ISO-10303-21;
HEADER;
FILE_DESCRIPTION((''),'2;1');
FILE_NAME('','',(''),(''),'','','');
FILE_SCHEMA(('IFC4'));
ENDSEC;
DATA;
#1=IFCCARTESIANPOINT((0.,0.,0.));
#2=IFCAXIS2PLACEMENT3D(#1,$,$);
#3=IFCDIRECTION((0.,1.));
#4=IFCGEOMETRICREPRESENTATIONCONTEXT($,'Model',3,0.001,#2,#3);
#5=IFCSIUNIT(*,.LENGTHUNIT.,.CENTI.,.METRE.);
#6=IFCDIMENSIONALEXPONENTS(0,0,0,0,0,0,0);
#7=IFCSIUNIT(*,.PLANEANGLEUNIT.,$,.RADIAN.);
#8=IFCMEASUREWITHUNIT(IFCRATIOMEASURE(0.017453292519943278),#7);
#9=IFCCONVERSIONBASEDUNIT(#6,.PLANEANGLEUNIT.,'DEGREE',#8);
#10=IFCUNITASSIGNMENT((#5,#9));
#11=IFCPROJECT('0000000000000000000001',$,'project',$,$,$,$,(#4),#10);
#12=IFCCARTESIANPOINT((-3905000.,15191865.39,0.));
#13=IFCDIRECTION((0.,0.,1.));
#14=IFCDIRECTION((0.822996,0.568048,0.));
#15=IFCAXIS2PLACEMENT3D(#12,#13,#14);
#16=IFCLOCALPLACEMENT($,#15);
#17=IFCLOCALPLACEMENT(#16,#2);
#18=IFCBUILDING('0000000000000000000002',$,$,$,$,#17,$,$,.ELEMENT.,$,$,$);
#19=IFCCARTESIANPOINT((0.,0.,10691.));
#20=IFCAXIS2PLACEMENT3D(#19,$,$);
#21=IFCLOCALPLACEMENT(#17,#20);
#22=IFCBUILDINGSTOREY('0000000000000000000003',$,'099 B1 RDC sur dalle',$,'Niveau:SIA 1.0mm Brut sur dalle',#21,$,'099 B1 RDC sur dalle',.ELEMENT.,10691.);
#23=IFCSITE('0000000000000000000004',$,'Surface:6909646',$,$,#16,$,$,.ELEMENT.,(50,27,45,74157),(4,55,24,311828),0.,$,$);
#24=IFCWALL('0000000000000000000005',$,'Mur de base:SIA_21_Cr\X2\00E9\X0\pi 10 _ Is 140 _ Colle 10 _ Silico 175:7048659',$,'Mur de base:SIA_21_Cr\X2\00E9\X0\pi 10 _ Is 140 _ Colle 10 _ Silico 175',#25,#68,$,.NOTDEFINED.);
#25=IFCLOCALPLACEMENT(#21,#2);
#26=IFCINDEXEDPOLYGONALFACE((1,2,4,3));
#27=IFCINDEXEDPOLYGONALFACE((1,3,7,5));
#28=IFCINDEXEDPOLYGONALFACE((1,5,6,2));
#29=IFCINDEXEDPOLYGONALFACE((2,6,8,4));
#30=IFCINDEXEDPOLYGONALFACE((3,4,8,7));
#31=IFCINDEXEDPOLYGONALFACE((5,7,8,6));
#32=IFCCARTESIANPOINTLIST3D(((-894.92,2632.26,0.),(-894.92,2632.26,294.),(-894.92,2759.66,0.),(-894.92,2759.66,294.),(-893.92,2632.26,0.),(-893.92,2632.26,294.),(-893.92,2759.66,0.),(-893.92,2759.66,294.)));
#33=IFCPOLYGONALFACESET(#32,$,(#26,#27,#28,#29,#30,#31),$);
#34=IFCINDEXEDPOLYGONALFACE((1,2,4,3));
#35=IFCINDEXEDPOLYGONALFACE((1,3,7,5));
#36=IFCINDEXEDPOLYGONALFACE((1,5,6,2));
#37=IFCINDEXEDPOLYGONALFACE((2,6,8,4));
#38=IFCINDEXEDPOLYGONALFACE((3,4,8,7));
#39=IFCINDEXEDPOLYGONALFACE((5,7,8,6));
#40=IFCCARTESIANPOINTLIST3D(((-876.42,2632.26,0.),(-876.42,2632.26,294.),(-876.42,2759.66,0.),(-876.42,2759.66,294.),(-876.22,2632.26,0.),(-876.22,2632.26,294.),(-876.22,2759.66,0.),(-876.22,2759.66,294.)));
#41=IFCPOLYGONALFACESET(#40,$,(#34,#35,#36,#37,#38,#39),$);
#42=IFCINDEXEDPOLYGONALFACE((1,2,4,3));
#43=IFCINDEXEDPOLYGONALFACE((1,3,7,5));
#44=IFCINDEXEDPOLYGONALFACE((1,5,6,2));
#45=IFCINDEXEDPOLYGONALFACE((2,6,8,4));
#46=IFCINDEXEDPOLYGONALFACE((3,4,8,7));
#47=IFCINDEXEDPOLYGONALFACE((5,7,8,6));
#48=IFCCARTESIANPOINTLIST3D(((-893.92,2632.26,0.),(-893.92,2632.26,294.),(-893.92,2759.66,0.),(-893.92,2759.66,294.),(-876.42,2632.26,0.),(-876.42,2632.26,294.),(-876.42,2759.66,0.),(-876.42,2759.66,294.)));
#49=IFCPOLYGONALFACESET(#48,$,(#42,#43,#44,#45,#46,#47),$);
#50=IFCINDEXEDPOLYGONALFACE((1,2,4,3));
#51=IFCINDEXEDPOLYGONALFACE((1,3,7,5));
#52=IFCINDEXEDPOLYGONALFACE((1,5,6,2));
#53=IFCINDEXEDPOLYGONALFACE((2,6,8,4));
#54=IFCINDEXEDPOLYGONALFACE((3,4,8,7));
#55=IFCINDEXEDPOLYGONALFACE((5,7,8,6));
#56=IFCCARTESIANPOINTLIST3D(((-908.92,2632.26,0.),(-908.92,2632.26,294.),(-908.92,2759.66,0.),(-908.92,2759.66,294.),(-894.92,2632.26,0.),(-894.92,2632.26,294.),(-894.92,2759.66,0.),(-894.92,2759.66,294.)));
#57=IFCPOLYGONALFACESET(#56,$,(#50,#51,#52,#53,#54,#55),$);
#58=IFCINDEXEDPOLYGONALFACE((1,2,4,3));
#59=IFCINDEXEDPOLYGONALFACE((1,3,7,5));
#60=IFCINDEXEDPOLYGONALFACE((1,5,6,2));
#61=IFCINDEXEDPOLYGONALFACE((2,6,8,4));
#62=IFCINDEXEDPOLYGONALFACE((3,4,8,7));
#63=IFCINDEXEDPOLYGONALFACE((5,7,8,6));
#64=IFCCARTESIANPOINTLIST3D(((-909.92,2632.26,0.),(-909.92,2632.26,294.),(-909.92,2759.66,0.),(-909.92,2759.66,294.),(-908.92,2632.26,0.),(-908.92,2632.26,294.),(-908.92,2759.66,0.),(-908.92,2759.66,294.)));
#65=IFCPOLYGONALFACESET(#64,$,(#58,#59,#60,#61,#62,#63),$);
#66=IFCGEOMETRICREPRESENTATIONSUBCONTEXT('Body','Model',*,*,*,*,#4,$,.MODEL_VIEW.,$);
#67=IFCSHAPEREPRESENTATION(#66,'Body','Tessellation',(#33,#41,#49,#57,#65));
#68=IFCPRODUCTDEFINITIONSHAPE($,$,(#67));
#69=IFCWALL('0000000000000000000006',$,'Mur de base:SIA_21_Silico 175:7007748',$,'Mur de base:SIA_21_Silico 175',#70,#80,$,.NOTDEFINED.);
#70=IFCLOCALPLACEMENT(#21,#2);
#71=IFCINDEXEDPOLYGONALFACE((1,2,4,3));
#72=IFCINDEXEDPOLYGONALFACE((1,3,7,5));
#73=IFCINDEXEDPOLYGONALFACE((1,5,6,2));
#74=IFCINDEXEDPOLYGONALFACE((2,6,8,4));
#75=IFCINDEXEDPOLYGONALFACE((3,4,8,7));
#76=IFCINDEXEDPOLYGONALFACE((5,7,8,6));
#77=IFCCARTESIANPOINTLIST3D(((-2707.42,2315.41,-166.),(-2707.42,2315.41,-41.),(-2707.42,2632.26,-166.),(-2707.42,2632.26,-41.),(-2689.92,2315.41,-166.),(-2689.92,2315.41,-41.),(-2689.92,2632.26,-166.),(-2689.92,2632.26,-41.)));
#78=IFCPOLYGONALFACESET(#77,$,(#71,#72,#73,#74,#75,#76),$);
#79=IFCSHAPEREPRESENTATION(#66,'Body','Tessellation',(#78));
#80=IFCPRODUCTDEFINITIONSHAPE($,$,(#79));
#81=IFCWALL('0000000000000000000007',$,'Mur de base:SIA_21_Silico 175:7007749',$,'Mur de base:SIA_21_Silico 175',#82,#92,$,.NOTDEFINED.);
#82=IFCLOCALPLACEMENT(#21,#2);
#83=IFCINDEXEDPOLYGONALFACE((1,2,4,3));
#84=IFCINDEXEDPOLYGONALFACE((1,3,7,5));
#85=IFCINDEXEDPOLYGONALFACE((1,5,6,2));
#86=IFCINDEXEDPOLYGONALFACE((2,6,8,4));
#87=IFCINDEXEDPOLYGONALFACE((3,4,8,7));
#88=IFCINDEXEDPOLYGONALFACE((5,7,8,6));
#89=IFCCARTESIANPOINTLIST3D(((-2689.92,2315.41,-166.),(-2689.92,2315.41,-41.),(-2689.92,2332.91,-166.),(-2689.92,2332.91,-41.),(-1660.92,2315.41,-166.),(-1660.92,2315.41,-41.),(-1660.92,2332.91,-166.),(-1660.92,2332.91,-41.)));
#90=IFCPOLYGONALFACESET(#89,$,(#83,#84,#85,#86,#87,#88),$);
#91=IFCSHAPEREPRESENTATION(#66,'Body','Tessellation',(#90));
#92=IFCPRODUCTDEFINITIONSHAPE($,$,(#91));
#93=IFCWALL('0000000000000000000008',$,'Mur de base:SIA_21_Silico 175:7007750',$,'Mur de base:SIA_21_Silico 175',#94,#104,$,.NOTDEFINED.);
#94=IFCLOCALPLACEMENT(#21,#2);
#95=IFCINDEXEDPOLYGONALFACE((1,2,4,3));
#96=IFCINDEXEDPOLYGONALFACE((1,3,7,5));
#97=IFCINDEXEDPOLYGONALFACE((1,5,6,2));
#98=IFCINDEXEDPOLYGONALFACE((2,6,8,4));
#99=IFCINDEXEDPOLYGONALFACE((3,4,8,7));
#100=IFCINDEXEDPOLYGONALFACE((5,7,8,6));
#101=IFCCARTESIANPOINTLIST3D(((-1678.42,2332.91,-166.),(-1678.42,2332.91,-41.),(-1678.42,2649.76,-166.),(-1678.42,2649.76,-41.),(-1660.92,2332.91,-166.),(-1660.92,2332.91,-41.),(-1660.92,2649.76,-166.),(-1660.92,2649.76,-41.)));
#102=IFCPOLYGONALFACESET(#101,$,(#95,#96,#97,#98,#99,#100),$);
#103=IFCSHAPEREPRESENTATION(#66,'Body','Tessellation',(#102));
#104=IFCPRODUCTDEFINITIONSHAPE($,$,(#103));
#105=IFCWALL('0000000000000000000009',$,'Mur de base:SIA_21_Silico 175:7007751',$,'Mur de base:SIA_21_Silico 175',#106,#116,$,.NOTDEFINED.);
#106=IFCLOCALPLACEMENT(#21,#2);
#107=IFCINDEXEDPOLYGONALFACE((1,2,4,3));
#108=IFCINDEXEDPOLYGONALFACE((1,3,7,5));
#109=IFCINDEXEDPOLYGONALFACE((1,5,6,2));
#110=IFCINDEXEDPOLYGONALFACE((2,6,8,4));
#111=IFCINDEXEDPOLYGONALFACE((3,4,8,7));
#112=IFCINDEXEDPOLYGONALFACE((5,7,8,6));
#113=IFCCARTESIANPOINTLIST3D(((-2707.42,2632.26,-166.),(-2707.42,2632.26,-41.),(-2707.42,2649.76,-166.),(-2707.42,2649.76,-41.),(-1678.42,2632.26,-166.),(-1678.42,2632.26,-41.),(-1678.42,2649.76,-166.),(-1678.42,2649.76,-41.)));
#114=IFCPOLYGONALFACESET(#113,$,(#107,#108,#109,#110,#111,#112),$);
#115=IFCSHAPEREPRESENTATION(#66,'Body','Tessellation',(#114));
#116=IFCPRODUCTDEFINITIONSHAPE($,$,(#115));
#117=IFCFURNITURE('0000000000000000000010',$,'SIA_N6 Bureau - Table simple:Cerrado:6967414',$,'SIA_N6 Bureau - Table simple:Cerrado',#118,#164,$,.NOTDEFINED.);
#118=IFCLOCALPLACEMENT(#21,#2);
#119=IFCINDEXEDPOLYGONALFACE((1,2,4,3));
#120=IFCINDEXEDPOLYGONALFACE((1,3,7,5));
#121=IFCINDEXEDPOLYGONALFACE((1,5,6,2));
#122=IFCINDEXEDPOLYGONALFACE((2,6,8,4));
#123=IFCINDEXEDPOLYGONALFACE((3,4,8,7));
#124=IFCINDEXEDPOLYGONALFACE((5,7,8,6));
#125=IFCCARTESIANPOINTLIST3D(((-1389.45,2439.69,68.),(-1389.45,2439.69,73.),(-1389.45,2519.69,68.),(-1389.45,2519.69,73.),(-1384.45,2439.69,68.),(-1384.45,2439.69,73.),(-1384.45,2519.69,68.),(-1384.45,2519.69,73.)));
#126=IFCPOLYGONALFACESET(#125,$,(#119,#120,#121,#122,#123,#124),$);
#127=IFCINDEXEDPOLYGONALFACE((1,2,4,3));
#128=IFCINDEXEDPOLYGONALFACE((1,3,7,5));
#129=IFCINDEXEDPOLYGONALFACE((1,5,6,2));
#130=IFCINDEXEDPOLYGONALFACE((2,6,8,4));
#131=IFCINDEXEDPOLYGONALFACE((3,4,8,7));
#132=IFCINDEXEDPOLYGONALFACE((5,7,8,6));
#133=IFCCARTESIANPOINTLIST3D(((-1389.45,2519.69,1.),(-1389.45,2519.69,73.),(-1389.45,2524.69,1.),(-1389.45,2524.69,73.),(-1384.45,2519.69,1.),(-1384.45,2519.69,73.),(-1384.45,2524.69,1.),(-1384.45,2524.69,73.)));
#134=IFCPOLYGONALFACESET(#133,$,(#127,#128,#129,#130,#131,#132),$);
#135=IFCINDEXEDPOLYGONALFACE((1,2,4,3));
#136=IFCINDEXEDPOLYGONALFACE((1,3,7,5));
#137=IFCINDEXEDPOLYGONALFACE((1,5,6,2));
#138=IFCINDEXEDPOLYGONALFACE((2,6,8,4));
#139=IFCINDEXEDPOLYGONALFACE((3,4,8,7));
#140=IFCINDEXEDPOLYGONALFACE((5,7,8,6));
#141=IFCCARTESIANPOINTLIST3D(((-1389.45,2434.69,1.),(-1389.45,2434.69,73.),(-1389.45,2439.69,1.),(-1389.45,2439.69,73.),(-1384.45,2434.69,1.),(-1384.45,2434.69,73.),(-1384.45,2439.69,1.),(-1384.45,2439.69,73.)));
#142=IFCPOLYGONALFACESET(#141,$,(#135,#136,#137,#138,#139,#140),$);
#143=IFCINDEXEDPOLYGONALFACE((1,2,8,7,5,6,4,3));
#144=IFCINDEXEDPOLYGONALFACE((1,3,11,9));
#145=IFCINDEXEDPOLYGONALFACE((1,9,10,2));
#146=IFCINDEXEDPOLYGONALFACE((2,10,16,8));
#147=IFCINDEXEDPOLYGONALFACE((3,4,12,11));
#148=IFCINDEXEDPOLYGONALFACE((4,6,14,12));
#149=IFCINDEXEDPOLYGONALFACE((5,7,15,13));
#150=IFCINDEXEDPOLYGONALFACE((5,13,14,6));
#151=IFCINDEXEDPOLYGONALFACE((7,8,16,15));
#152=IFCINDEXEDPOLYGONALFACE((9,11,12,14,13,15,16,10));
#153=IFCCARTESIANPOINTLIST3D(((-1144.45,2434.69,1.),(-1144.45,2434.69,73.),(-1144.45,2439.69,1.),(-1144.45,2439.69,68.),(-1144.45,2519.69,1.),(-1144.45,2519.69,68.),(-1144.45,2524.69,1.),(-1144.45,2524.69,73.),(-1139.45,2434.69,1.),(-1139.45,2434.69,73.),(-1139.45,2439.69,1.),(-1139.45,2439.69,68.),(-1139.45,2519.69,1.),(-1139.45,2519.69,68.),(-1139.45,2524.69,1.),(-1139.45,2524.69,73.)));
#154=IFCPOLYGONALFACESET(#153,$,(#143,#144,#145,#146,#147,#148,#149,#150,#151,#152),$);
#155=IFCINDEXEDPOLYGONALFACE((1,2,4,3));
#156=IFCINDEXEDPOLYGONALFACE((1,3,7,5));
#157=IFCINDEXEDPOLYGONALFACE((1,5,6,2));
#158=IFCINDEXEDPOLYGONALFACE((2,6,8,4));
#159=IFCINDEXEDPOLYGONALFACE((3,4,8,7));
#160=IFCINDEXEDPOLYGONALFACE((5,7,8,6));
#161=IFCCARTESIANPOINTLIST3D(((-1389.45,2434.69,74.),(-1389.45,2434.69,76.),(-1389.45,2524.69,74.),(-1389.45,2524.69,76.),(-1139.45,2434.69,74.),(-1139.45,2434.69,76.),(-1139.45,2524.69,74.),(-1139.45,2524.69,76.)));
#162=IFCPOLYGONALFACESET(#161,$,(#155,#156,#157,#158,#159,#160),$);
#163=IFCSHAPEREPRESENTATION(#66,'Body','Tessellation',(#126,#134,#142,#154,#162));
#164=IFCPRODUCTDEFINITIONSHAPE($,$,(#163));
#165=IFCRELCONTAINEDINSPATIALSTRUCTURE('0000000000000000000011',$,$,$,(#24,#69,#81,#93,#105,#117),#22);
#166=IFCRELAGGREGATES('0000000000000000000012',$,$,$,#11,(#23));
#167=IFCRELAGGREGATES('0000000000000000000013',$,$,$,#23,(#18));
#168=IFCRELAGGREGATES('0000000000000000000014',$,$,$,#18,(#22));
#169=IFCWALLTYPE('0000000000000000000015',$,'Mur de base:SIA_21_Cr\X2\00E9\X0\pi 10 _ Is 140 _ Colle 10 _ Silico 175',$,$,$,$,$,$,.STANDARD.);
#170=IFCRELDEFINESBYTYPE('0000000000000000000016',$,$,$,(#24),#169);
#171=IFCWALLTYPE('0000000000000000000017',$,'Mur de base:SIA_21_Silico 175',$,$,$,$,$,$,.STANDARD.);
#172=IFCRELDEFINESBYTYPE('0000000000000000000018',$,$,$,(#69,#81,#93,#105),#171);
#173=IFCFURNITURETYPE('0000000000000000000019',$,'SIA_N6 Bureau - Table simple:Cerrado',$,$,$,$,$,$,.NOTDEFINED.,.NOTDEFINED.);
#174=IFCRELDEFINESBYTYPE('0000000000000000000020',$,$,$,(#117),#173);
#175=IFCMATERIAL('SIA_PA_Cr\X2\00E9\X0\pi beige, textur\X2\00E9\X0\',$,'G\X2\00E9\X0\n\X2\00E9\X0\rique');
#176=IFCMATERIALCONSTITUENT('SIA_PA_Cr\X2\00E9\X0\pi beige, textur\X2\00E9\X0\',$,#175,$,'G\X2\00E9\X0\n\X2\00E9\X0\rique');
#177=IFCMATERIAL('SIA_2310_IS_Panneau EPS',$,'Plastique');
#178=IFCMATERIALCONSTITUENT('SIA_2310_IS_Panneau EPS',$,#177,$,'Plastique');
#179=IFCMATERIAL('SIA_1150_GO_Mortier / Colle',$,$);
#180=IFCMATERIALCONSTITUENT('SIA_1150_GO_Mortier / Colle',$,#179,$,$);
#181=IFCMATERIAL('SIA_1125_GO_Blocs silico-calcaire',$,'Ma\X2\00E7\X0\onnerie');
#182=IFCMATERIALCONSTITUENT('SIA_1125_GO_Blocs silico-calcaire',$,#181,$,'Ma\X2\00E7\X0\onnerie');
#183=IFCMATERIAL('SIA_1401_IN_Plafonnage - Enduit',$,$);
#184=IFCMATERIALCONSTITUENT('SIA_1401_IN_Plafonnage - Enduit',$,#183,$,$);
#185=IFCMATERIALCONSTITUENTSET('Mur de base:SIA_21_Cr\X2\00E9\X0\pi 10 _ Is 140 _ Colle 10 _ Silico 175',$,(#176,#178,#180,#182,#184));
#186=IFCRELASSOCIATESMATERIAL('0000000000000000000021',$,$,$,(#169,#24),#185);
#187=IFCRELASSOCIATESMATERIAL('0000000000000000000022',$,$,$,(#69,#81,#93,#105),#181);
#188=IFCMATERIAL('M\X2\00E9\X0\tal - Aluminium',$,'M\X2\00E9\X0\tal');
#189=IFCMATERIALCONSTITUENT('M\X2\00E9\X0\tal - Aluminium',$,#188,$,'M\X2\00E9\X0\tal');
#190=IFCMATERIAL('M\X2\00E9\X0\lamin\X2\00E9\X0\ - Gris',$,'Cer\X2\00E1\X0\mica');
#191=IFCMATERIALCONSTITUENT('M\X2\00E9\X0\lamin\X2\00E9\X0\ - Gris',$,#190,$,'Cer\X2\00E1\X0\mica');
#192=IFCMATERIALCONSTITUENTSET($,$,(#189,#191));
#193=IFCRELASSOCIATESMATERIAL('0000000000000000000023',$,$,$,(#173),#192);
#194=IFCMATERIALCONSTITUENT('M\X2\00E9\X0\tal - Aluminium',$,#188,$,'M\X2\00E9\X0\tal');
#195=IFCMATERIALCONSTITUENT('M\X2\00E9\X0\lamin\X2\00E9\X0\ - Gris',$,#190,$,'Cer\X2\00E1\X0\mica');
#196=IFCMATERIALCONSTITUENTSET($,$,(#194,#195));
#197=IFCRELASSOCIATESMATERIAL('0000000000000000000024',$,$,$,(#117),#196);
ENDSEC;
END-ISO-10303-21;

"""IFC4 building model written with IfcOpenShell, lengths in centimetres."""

from ifc_helpers import new_model, entity, si_unit, converted_unit, direction, frame, origin, place, context, subcontext, project, spatial, indexed_curve, outline, extrude, source, transform, mapped, material, constituent, constituent_set, type_object, type_shapes, element, save


model = new_model("IFC4")

# Units and contexts
model_context = context("Model", 3, precision=0.001, world=origin(), true_north=direction((0.0, 1.0)))
body_context = subcontext(model_context, "Body", "Model", "MODEL_VIEW")
ifc_project = project(units=[si_unit("LENGTHUNIT", "METRE", prefix="CENTI"), converted_unit("PLANEANGLEUNIT", "DEGREE", entity("IfcRatioMeasure", 0.017453292519943278), si_unit("PLANEANGLEUNIT", "RADIAN"), dimensions=[0, 0, 0, 0, 0, 0, 0])], contexts=[model_context])

# Site, building, storey
site_placement = place(None, frame((-3905000.0, 15191865.39, 0.0), z_axis=(0.0, 0.0, 1.0), x_axis=(0.822996, 0.568048, 0.0)))
site = spatial("IfcSite", under=ifc_project, at=site_placement, Name="Surface:6909646", CompositionType="ELEMENT", RefLatitude=(50, 27, 45, 74157), RefLongitude=(4, 55, 24, 311828), RefElevation=0.0)
building_placement = place(site_placement, origin())
building = spatial("IfcBuilding", under=site, at=building_placement, CompositionType="ELEMENT")
storey_placement = place(building_placement, frame((0.0, 0.0, 10691.0)))
storey = spatial("IfcBuildingStorey", under=building, at=storey_placement, Name="099 B1 RDC sur dalle", ObjectType="Niveau:SIA 1.0mm Brut sur dalle", LongName="099 B1 RDC sur dalle", CompositionType="ELEMENT", Elevation=10691.0)

# Walls
ifc_material_1 = material(Name="SIA_PA_Crépi beige, texturé", Category="Générique")
ifc_constituent_1 = constituent(ifc_material_1, Name="SIA_PA_Crépi beige, texturé", Category="Générique")
ifc_material_2 = material(Name="SIA_2310_IS_Panneau EPS", Category="Plastique")
ifc_constituent_2 = constituent(ifc_material_2, Name="SIA_2310_IS_Panneau EPS", Category="Plastique")
ifc_material_3 = material(Name="SIA_1150_GO_Mortier / Colle")
ifc_constituent_3 = constituent(ifc_material_3, Name="SIA_1150_GO_Mortier / Colle")
ifc_material_4 = material(Name="SIA_1125_GO_Blocs silico-calcaire", Category="Maçonnerie")
ifc_constituent_4 = constituent(ifc_material_4, Name="SIA_1125_GO_Blocs silico-calcaire", Category="Maçonnerie")
ifc_material_5 = material(Name="SIA_1401_IN_Plafonnage - Enduit")
ifc_constituent_5 = constituent(ifc_material_5, Name="SIA_1401_IN_Plafonnage - Enduit")
ifc_constituent_set_1 = constituent_set(constituents=[ifc_constituent_1, ifc_constituent_2, ifc_constituent_3, ifc_constituent_4, ifc_constituent_5], Name="Mur de base:SIA_21_Crépi 10 _ Is 140 _ Colle 10 _ Silico 175")
wall_type_1 = type_object("IfcWallType", Name="Mur de base:SIA_21_Crépi 10 _ Is 140 _ Colle 10 _ Silico 175", PredefinedType="STANDARD", material=ifc_constituent_set_1)
wall_1_placement = place(storey_placement, frame((-893.07, 2632.26, 0.0), z_axis=(0.0, 0.0, 1.0), x_axis=(0.0, 1.0, 0.0)))
element("IfcWall", 1, at=wall_1_placement, inside=storey, type_object=wall_type_1, material=ifc_constituent_set_1, Name="Mur de base:SIA_21_Crépi 10 _ Is 140 _ Colle 10 _ Silico 175:7048659", ObjectType="Mur de base:SIA_21_Crépi 10 _ Is 140 _ Colle 10 _ Silico 175", PredefinedType="NOTDEFINED", context=body_context, shape_type="SweptSolid", body=[
    extrude(outline(indexed_curve([(-147.0, -63.7), (147.0, -63.7), (147.0, 63.7), (-147.0, 63.7), (-147.0, -63.7)], self_intersect=False)), frame((63.7, 1.85, 147.0), z_axis=(0.0, -1.0, 0.0), x_axis=(0.0, 0.0, 1.0)), (0.0, 0.0, 1.0), 1.0),
    extrude(outline(indexed_curve([(-147.0, -63.7), (147.0, -63.7), (147.0, 63.7), (-147.0, 63.7), (-147.0, -63.7)], self_intersect=False)), frame((63.7, -16.65, 147.0), z_axis=(0.0, -1.0, 0.0), x_axis=(0.0, 0.0, 1.0)), (0.0, 0.0, 1.0), 0.2),
    extrude(outline(indexed_curve([(-147.0, -63.7), (147.0, -63.7), (147.0, 63.7), (-147.0, 63.7), (-147.0, -63.7)], self_intersect=False)), frame((63.7, 0.85, 147.0), z_axis=(0.0, -1.0, 0.0), x_axis=(0.0, 0.0, 1.0)), (0.0, 0.0, 1.0), 17.5),
    extrude(outline(indexed_curve([(-147.0, -63.7), (147.0, -63.7), (147.0, 63.7), (-147.0, 63.7), (-147.0, -63.7)], self_intersect=False)), frame((63.7, 15.85, 147.0), z_axis=(0.0, -1.0, 0.0), x_axis=(0.0, 0.0, 1.0)), (0.0, 0.0, 1.0), 14.0),
    extrude(outline(indexed_curve([(-63.7, -147.0), (63.7, -147.0), (63.7, 147.0), (-63.7, 147.0), (-63.7, -147.0)], self_intersect=False)), frame((63.7, 16.85, 147.0), z_axis=(0.0, -1.0, 0.0), x_axis=(1.0, 0.0, 0.0)), (0.0, 0.0, 1.0), 1.0),
])
wall_type_2 = type_object("IfcWallType", Name="Mur de base:SIA_21_Silico 175", PredefinedType="STANDARD")
wall_2_placement = place(storey_placement, frame((-2698.67, 2315.41, -166.0), z_axis=(0.0, 0.0, 1.0), x_axis=(0.0, 1.0, 0.0)))
element("IfcWall", 2, at=wall_2_placement, inside=storey, type_object=wall_type_2, material=ifc_material_4, Name="Mur de base:SIA_21_Silico 175:7007748", ObjectType="Mur de base:SIA_21_Silico 175", PredefinedType="NOTDEFINED", context=body_context, shape_type="SweptSolid", body=[
    extrude(outline(indexed_curve([(316.85, 8.75), (0.0, 8.75), (0.0, -8.75), (316.85, -8.75), (316.85, 8.75)], self_intersect=False)), origin(), (0.0, 0.0, 1.0), 125.0),
])
wall_3_placement = place(storey_placement, frame((-1660.92, 2324.16, -166.0), z_axis=(0.0, 0.0, 1.0), x_axis=(-1.0, 0.0, 0.0)))
element("IfcWall", 3, at=wall_3_placement, inside=storey, type_object=wall_type_2, material=ifc_material_4, Name="Mur de base:SIA_21_Silico 175:7007749", ObjectType="Mur de base:SIA_21_Silico 175", PredefinedType="NOTDEFINED", context=body_context, shape_type="SweptSolid", body=[
    extrude(outline(indexed_curve([(1029.0, 8.75), (0.0, 8.75), (0.0, -8.75), (1029.0, -8.75), (1029.0, 8.75)], self_intersect=False)), origin(), (0.0, 0.0, 1.0), 125.0),
])
wall_4_placement = place(storey_placement, frame((-1669.67, 2649.76, -166.0), z_axis=(0.0, 0.0, 1.0), x_axis=(0.0, -1.0, 0.0)))
element("IfcWall", 4, at=wall_4_placement, inside=storey, type_object=wall_type_2, material=ifc_material_4, Name="Mur de base:SIA_21_Silico 175:7007750", ObjectType="Mur de base:SIA_21_Silico 175", PredefinedType="NOTDEFINED", context=body_context, shape_type="SweptSolid", body=[
    extrude(outline(indexed_curve([(316.85, 8.75), (0.0, 8.75), (0.0, -8.75), (316.85, -8.75), (316.85, 8.75)], self_intersect=False)), origin(), (0.0, 0.0, 1.0), 125.0),
])
wall_5_placement = place(storey_placement, frame((-2707.42, 2641.01, -166.0)))
element("IfcWall", 5, at=wall_5_placement, inside=storey, type_object=wall_type_2, material=ifc_material_4, Name="Mur de base:SIA_21_Silico 175:7007751", ObjectType="Mur de base:SIA_21_Silico 175", PredefinedType="NOTDEFINED", context=body_context, shape_type="SweptSolid", body=[
    extrude(outline(indexed_curve([(1029.0, 8.75), (0.0, 8.75), (0.0, -8.75), (1029.0, -8.75), (1029.0, 8.75)], self_intersect=False)), origin(), (0.0, 0.0, 1.0), 125.0),
])

# Furniture
ifc_material_6 = material(Name="Métal - Aluminium", Category="Métal")
ifc_constituent_6 = constituent(ifc_material_6, Name="Métal - Aluminium", Category="Métal")
ifc_material_7 = material(Name="Mélaminé - Gris", Category="Cerámica")
ifc_constituent_7 = constituent(ifc_material_7, Name="Mélaminé - Gris", Category="Cerámica")
ifc_constituent_set_2 = constituent_set(constituents=[ifc_constituent_6, ifc_constituent_7])
ifc_constituent_8 = constituent(ifc_material_6, Name="Métal - Aluminium", Category="Métal")
ifc_constituent_9 = constituent(ifc_material_7, Name="Mélaminé - Gris", Category="Cerámica")
ifc_constituent_set_3 = constituent_set(constituents=[ifc_constituent_8, ifc_constituent_9])
furniture_type = type_object("IfcFurnitureType", Name="SIA_N6 Bureau - Table simple:Cerrado", AssemblyPlace="NOTDEFINED", PredefinedType="NOTDEFINED", material=ifc_constituent_set_3)
shared_shape_1 = source(origin(), body_context, "Body", "SweptSolid", [
    extrude(outline(indexed_curve([(-40.0, -2.5), (40.0, -2.5), (40.0, 2.5), (-40.0, 2.5), (-40.0, -2.5)], self_intersect=False)), frame((-252.5, 0.0, 67.0), z_axis=(0.0, 0.0, 1.0), x_axis=(0.0, -1.0, 0.0)), (0.0, 0.0, 1.0), 5.0),
    extrude(outline(indexed_curve([(-2.5, -2.5), (2.5, -2.5), (2.5, 2.5), (-2.5, 2.5), (-2.5, -2.5)], self_intersect=False)), frame((-252.5, 42.5, 0.0), z_axis=(0.0, 0.0, 1.0), x_axis=(0.0, -1.0, 0.0)), (0.0, 0.0, 1.0), 72.0),
    extrude(outline(indexed_curve([(-2.5, -2.5), (2.5, -2.5), (2.5, 2.5), (-2.5, 2.5), (-2.5, -2.5)], self_intersect=False)), frame((-252.5, -42.5, 0.0), z_axis=(0.0, 0.0, 1.0), x_axis=(0.0, -1.0, 0.0)), (0.0, 0.0, 1.0), 72.0),
    extrude(outline(indexed_curve([(-45.0, -34.75), (-40.0, -34.75), (-40.0, 32.25), (40.0, 32.25), (40.0, -34.75), (45.0, -34.75), (45.0, 37.25), (-45.0, 37.25), (-45.0, -34.75)], self_intersect=False)), frame((-10.0, 0.0, 34.75), z_axis=(1.0, 0.0, 0.0), x_axis=(0.0, 1.0, 0.0)), (0.0, 0.0, 1.0), 5.0),
    extrude(outline(indexed_curve([(-125.0, -45.0), (125.0, -45.0), (125.0, 45.0), (-125.0, 45.0), (-125.0, -45.0)], self_intersect=False)), frame((-130.0, 0.0, 73.0), z_axis=(0.0, 0.0, 1.0), x_axis=(-1.0, 0.0, 0.0)), (0.0, 0.0, 1.0), 2.0),
])
type_shapes(furniture_type, [shared_shape_1])
furniture_placement = place(storey_placement, frame((-1134.45, 2479.69, 1.0)))
element("IfcFurniture", 6, at=furniture_placement, inside=storey, type_object=furniture_type, material=ifc_constituent_set_2, Name="SIA_N6 Bureau - Table simple:Cerrado:6967414", ObjectType="SIA_N6 Bureau - Table simple:Cerrado", PredefinedType="NOTDEFINED", context=body_context, shape_type="MappedRepresentation", body=[
    mapped(shared_shape_1, transform((0.0, 0.0, 0.0), scale=1.0)),
])

save(model, "model.ifc")
